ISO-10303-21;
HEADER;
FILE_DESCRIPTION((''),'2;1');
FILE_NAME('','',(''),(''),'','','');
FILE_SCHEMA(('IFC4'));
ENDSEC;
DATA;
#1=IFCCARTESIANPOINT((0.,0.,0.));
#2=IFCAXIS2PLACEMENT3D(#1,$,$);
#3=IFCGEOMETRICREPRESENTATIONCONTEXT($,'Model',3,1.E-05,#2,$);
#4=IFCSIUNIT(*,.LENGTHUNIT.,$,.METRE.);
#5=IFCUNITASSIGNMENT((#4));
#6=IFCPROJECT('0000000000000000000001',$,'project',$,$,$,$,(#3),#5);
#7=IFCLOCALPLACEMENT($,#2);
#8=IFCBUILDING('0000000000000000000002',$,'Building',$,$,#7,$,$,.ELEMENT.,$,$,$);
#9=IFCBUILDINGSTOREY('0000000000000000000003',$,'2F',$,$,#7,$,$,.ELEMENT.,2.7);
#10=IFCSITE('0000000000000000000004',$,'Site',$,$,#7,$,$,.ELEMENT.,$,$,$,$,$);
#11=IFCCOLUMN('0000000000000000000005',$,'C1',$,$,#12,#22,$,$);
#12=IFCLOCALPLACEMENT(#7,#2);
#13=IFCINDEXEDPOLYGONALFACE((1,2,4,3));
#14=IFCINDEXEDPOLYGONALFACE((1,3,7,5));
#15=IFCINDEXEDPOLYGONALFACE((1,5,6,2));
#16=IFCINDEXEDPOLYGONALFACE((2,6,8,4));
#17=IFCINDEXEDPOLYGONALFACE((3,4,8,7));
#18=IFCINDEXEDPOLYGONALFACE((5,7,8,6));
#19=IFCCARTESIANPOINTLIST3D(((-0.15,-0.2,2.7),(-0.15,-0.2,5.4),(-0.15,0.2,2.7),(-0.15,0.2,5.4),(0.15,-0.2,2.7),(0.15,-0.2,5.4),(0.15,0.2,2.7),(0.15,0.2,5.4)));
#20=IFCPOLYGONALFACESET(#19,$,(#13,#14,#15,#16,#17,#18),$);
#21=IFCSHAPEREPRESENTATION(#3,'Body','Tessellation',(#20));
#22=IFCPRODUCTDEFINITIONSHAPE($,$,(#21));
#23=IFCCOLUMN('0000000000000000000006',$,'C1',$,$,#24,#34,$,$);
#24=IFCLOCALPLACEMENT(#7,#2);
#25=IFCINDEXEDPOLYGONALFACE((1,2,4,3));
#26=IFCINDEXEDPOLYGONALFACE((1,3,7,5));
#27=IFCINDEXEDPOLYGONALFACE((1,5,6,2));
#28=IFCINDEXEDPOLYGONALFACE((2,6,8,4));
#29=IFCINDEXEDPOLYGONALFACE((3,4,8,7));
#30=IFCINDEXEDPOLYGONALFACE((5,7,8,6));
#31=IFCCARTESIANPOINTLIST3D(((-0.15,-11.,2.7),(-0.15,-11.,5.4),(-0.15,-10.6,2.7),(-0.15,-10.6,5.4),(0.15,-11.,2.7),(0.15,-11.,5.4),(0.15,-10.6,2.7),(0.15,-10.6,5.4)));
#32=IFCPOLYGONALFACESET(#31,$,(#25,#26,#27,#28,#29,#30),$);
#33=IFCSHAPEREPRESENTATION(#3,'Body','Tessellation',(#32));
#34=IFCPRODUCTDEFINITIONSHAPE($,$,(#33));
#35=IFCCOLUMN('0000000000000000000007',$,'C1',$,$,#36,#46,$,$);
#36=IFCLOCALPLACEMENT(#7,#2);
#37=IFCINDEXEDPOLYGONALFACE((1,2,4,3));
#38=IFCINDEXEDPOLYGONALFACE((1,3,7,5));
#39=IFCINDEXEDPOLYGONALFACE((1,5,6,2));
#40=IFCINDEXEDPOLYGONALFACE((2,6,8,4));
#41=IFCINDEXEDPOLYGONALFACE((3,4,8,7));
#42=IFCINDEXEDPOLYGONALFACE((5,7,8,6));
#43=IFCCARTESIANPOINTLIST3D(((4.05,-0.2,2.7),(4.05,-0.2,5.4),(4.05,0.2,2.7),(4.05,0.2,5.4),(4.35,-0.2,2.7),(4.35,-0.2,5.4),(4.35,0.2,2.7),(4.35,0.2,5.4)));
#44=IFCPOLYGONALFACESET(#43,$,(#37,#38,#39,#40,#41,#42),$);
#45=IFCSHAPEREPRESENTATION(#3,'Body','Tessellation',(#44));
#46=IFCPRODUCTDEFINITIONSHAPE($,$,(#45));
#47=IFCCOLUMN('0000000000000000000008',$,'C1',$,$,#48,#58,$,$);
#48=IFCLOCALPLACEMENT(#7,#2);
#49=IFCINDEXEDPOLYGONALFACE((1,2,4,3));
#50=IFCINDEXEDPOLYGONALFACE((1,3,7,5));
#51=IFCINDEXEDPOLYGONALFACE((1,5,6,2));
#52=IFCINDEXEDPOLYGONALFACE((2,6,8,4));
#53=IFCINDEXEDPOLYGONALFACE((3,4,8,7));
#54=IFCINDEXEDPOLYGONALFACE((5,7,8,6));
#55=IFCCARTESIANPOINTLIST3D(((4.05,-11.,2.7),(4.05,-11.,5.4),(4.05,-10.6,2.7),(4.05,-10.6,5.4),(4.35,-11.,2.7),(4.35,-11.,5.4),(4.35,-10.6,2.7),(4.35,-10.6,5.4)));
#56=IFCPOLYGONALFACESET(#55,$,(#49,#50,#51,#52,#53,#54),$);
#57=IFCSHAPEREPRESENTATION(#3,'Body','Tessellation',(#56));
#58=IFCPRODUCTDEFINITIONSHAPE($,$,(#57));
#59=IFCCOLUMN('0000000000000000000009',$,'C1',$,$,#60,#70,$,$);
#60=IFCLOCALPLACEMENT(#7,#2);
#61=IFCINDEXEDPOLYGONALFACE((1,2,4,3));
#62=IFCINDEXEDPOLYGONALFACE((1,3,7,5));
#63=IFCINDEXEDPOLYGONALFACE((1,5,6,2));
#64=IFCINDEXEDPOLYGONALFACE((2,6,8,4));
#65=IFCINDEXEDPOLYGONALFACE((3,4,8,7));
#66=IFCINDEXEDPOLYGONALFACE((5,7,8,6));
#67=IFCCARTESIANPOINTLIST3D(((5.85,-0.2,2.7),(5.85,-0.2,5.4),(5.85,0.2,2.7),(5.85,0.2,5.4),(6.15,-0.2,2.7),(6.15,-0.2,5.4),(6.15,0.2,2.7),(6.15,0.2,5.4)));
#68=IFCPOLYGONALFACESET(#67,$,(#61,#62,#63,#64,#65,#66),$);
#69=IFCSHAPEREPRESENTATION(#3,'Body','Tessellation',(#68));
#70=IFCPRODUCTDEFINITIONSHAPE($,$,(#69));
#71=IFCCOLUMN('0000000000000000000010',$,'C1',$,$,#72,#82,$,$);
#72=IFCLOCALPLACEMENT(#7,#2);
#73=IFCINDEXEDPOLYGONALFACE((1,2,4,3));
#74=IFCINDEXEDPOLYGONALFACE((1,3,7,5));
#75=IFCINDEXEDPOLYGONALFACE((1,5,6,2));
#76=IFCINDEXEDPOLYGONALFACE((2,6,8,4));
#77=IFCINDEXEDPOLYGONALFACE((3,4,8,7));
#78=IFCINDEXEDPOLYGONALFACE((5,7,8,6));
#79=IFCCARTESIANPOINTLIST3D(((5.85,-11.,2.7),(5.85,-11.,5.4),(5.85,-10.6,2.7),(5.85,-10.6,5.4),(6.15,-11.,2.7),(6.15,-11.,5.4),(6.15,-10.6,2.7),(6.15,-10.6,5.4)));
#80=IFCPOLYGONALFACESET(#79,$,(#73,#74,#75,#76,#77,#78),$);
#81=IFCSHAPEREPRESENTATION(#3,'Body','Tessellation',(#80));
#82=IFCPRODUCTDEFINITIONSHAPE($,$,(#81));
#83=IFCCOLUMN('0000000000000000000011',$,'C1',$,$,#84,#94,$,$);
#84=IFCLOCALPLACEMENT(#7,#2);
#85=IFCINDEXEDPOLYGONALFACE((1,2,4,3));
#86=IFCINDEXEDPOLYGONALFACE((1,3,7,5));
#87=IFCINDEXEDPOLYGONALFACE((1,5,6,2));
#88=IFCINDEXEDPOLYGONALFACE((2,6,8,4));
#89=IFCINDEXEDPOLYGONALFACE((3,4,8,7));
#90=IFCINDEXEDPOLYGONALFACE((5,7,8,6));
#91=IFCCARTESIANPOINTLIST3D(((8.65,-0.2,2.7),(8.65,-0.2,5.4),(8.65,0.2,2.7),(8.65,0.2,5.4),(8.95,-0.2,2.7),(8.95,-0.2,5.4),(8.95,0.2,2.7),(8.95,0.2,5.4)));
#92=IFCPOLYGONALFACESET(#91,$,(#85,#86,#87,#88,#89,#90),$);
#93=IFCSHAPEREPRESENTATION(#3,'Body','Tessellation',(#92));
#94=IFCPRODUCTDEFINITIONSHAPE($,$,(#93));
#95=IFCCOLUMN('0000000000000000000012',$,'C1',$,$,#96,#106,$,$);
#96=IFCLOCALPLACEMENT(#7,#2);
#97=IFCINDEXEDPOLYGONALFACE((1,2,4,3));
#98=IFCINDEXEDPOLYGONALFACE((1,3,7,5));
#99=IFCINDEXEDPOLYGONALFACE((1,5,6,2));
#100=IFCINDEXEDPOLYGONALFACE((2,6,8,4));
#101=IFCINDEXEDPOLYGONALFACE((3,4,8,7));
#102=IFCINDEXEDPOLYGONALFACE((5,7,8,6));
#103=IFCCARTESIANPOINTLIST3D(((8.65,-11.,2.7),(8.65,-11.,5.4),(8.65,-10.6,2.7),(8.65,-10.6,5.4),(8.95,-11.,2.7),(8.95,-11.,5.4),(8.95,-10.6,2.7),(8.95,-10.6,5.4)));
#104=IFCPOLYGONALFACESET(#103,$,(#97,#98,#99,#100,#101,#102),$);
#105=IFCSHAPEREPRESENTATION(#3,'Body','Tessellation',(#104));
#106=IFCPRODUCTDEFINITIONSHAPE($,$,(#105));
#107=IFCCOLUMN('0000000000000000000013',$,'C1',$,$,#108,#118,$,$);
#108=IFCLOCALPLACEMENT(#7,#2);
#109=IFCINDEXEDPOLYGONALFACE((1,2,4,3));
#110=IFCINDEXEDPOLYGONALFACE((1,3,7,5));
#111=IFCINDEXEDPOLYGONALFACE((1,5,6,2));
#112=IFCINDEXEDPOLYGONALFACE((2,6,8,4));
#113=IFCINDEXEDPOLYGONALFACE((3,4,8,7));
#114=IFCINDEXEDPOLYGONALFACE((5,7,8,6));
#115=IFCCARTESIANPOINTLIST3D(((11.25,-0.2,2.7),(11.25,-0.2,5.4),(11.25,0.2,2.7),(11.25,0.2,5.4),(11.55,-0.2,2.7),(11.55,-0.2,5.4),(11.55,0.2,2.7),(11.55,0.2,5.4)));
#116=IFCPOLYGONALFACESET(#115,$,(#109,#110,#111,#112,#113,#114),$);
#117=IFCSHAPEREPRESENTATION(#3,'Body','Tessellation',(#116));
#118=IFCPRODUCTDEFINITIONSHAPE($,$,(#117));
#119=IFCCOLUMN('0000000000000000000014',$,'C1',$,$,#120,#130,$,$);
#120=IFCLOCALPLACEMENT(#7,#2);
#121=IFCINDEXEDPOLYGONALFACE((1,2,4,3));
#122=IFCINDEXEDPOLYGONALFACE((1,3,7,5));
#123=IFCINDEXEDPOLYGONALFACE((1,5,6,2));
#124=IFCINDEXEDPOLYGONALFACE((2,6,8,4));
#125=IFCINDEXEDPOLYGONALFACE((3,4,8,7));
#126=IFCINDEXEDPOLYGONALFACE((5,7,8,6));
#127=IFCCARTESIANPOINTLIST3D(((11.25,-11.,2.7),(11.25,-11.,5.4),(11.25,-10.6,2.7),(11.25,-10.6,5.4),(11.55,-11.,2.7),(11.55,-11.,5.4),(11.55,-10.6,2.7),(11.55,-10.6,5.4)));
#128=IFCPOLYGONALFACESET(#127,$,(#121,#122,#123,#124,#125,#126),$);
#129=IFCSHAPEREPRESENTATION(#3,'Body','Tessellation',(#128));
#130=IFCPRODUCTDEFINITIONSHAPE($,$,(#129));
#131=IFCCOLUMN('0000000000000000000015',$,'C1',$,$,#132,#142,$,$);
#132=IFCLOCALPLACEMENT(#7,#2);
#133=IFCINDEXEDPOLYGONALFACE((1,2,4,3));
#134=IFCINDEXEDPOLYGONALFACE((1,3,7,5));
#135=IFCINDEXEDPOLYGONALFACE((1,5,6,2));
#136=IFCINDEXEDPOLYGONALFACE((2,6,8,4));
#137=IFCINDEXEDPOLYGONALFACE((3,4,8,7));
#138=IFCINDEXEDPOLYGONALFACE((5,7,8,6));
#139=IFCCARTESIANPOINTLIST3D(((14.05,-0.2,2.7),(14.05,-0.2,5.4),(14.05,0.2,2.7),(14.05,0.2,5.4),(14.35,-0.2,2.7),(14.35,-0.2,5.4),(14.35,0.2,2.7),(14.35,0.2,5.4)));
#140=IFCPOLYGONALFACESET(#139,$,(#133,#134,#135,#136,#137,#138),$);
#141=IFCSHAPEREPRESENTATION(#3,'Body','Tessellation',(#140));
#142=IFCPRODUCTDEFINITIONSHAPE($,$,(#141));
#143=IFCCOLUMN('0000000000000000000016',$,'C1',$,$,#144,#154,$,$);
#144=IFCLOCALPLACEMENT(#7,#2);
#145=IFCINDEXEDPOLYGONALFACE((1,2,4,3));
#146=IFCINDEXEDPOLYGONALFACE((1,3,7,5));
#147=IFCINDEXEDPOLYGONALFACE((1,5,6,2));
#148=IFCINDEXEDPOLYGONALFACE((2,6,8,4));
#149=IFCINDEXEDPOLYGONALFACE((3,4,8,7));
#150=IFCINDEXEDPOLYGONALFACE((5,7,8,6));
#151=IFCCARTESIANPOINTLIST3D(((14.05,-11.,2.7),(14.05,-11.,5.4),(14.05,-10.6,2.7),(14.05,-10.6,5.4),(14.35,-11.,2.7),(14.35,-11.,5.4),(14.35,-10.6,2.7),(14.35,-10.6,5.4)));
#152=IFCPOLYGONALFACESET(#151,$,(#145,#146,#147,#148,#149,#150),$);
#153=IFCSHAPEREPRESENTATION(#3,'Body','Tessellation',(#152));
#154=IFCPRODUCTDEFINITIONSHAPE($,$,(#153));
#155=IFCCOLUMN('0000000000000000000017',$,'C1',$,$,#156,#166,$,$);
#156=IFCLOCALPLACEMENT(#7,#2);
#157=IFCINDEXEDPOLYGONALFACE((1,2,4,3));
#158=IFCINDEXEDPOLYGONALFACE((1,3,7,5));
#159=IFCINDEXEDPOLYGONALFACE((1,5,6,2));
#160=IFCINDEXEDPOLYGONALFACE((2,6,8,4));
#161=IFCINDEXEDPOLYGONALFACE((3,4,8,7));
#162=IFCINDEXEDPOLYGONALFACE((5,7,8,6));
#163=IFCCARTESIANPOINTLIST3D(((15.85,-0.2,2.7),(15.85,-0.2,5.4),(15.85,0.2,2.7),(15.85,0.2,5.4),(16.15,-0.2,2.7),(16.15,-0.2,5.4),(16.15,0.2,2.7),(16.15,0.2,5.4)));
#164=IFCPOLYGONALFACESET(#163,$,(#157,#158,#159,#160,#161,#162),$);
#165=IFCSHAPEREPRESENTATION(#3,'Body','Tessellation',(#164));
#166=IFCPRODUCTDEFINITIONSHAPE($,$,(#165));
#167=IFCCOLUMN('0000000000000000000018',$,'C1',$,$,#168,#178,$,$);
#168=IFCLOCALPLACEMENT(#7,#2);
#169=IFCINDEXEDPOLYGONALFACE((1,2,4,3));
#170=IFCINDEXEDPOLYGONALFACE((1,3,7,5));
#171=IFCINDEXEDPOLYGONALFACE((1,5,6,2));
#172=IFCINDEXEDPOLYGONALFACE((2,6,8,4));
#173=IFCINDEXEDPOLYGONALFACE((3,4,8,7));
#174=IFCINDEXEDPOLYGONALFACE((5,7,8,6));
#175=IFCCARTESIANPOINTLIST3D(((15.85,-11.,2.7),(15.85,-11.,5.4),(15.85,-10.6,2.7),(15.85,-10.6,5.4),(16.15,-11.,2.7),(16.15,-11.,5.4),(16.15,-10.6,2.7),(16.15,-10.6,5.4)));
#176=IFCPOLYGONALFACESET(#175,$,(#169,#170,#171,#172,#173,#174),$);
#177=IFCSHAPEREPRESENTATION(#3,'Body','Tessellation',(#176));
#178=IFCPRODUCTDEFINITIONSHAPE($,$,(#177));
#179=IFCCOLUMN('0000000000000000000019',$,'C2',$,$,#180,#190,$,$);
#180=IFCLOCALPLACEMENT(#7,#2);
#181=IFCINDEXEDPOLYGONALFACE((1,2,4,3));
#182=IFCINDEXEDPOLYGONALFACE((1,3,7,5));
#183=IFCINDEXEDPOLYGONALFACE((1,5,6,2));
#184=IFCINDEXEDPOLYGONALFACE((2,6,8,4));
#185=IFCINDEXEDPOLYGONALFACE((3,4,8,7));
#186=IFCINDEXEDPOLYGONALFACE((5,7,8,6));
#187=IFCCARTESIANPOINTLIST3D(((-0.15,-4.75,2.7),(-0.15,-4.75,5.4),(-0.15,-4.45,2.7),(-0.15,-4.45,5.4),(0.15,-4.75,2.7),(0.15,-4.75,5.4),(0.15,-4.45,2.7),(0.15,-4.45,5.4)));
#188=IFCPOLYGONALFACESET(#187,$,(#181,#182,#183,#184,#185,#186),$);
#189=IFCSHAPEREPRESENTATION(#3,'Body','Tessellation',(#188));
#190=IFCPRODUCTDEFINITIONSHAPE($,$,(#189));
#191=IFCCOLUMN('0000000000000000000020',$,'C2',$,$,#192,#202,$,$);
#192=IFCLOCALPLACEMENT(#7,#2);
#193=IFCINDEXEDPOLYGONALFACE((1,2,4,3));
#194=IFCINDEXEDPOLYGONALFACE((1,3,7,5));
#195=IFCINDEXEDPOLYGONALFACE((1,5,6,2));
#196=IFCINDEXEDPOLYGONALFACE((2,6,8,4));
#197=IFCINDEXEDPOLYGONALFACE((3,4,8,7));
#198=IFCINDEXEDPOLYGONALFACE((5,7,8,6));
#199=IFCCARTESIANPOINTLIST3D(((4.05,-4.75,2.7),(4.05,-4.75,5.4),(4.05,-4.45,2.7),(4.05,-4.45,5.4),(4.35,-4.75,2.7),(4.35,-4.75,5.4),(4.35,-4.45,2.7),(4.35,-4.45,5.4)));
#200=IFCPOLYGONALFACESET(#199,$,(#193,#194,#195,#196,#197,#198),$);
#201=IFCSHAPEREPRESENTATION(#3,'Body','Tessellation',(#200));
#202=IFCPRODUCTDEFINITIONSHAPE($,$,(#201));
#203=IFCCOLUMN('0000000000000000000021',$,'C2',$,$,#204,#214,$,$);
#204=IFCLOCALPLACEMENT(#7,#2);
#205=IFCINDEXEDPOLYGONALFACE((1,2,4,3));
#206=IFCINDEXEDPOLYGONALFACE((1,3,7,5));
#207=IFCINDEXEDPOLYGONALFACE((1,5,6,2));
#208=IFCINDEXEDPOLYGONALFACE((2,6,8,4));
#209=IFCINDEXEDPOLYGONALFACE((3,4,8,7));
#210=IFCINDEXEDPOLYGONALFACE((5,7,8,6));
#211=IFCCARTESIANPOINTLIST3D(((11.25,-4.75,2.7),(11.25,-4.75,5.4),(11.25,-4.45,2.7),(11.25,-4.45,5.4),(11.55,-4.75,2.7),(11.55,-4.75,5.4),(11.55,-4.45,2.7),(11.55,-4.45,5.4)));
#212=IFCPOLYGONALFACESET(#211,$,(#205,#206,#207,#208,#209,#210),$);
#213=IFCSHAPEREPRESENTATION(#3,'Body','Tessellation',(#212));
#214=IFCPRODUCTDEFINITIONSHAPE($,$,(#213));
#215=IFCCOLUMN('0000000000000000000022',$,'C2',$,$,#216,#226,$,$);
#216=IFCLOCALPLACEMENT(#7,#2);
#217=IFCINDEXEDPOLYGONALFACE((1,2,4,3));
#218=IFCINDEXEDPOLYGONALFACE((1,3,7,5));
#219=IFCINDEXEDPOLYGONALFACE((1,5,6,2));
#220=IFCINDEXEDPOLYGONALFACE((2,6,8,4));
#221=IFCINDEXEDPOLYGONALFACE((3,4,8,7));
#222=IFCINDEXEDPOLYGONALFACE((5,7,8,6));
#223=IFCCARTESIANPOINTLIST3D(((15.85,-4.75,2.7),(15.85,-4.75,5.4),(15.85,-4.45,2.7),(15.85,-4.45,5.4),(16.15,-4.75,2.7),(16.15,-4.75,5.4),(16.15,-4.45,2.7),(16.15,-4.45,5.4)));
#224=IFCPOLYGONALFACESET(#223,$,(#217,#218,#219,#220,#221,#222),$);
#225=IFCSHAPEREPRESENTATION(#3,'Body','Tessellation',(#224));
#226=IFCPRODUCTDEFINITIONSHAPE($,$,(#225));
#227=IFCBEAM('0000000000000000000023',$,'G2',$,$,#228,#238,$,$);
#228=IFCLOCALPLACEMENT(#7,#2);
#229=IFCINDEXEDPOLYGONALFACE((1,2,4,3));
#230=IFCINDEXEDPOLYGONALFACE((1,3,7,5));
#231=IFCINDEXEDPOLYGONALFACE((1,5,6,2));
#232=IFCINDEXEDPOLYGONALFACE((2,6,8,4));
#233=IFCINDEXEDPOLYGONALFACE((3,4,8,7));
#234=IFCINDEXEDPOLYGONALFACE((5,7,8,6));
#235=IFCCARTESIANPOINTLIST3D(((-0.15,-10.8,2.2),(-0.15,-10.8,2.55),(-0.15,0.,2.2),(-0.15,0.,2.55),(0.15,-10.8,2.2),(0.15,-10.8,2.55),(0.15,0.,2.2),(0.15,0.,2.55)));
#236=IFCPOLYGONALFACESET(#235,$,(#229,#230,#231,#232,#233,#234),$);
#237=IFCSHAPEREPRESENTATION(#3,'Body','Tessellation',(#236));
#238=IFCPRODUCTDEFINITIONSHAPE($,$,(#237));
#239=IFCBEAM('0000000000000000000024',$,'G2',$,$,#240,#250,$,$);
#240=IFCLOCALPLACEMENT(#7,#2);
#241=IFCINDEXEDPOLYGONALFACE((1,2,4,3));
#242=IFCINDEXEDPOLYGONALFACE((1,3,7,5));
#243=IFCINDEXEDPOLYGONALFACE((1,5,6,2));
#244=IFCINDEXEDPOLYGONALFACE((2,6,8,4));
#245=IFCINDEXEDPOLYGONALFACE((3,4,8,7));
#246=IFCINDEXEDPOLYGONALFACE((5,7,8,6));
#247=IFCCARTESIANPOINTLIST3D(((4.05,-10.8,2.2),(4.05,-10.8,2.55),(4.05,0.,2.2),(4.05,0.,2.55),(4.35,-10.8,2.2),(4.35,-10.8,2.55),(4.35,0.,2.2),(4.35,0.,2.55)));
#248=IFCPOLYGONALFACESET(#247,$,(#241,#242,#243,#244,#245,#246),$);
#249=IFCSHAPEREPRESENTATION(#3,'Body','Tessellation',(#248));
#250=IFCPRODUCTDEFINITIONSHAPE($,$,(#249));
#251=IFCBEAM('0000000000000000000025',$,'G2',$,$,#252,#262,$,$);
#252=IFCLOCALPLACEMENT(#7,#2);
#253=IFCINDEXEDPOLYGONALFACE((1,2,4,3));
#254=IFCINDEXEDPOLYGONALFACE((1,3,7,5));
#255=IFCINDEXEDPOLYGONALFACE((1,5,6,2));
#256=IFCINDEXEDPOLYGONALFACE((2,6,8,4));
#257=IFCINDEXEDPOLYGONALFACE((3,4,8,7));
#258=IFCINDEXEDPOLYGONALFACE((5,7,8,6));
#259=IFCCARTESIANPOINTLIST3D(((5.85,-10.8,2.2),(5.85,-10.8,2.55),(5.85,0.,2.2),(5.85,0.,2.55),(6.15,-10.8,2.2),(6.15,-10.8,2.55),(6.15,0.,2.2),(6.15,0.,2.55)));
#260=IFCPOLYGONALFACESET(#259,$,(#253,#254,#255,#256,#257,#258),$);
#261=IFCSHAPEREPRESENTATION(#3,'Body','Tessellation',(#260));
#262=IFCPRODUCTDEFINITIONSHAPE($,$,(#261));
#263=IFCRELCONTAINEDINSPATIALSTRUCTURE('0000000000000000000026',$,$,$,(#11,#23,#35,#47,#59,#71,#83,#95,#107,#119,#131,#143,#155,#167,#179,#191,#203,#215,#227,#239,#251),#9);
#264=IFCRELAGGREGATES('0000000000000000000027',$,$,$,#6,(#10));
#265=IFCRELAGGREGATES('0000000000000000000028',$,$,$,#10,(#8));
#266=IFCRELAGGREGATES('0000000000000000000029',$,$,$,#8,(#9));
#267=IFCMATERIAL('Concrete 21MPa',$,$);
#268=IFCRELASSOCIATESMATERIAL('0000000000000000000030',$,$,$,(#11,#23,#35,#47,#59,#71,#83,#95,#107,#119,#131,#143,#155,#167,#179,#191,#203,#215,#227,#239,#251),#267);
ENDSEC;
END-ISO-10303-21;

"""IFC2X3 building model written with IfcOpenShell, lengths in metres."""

from ifc_helpers import new_model, si_unit, frame, origin, origin_2d, place, context, project, spatial, rectangle, extrude, material, element, save


model = new_model("IFC2X3")

# Units and contexts
model_context = context("Model", 3, precision=1e-05, world=origin())
ifc_project = project(units=[si_unit("LENGTHUNIT", "METRE")], contexts=[model_context])

# Site, building, storey
placement = place(None, origin())
site = spatial("IfcSite", under=ifc_project, at=placement, Name="Site", CompositionType="ELEMENT")
building = spatial("IfcBuilding", under=site, at=placement, Name="Building", CompositionType="ELEMENT")
storey = spatial("IfcBuildingStorey", under=building, at=placement, Name="2F", CompositionType="ELEMENT", Elevation=2.7)

# Columns
ifc_material = material(Name="Concrete 21MPa")
for number, where, name in (
    (1, (0.0, 0.0, 2.7), "C1"),
    (2, (0.0, -10.8, 2.7), "C1"),
    (3, (4.2, 0.0, 2.7), "C1"),
    (4, (4.2, -10.8, 2.7), "C1"),
    (5, (6.0, 0.0, 2.7), "C1"),
    (6, (6.0, -10.8, 2.7), "C1"),
    (7, (8.8, 0.0, 2.7), "C1"),
    (8, (8.8, -10.8, 2.7), "C1"),
    (9, (11.4, 0.0, 2.7), "C1"),
    (10, (11.4, -10.8, 2.7), "C1"),
    (11, (14.2, 0.0, 2.7), "C1"),
    (12, (14.2, -10.8, 2.7), "C1"),
    (13, (16.0, 0.0, 2.7), "C1"),
    (14, (16.0, -10.8, 2.7), "C1"),
):
    element("IfcColumn", number, at=place(None, frame(where)), inside=storey, material=ifc_material, Name=name, context=model_context, shape_type="SweptSolid", body=[
        extrude(rectangle(XDim=0.3, YDim=0.4, at=origin_2d()), origin(), (0.0, 0.0, 1.0), 2.7),
    ])
for number, where, name in (
    (15, (0.0, -4.6, 2.7), "C2"),
    (16, (4.2, -4.6, 2.7), "C2"),
    (17, (11.4, -4.6, 2.7), "C2"),
    (18, (16.0, -4.6, 2.7), "C2"),
):
    element("IfcColumn", number, at=place(None, frame(where)), inside=storey, material=ifc_material, Name=name, context=model_context, shape_type="SweptSolid", body=[
        extrude(rectangle(XDim=0.3, YDim=0.3, at=origin_2d()), origin(), (0.0, 0.0, 1.0), 2.7),
    ])

# Beams
for number, where, name in (
    (19, (0.0, -5.4, 2.2), "G2"),
    (20, (4.2, -5.4, 2.2), "G2"),
    (21, (6.0, -5.4, 2.2), "G2"),
):
    element("IfcBeam", number, at=place(None, frame(where)), inside=storey, material=ifc_material, Name=name, context=model_context, shape_type="SweptSolid", body=[
        extrude(rectangle(XDim=0.3, YDim=10.8, at=origin_2d()), origin(), (0.0, 0.0, 1.0), 0.35),
    ])

save(model, "model.ifc")
